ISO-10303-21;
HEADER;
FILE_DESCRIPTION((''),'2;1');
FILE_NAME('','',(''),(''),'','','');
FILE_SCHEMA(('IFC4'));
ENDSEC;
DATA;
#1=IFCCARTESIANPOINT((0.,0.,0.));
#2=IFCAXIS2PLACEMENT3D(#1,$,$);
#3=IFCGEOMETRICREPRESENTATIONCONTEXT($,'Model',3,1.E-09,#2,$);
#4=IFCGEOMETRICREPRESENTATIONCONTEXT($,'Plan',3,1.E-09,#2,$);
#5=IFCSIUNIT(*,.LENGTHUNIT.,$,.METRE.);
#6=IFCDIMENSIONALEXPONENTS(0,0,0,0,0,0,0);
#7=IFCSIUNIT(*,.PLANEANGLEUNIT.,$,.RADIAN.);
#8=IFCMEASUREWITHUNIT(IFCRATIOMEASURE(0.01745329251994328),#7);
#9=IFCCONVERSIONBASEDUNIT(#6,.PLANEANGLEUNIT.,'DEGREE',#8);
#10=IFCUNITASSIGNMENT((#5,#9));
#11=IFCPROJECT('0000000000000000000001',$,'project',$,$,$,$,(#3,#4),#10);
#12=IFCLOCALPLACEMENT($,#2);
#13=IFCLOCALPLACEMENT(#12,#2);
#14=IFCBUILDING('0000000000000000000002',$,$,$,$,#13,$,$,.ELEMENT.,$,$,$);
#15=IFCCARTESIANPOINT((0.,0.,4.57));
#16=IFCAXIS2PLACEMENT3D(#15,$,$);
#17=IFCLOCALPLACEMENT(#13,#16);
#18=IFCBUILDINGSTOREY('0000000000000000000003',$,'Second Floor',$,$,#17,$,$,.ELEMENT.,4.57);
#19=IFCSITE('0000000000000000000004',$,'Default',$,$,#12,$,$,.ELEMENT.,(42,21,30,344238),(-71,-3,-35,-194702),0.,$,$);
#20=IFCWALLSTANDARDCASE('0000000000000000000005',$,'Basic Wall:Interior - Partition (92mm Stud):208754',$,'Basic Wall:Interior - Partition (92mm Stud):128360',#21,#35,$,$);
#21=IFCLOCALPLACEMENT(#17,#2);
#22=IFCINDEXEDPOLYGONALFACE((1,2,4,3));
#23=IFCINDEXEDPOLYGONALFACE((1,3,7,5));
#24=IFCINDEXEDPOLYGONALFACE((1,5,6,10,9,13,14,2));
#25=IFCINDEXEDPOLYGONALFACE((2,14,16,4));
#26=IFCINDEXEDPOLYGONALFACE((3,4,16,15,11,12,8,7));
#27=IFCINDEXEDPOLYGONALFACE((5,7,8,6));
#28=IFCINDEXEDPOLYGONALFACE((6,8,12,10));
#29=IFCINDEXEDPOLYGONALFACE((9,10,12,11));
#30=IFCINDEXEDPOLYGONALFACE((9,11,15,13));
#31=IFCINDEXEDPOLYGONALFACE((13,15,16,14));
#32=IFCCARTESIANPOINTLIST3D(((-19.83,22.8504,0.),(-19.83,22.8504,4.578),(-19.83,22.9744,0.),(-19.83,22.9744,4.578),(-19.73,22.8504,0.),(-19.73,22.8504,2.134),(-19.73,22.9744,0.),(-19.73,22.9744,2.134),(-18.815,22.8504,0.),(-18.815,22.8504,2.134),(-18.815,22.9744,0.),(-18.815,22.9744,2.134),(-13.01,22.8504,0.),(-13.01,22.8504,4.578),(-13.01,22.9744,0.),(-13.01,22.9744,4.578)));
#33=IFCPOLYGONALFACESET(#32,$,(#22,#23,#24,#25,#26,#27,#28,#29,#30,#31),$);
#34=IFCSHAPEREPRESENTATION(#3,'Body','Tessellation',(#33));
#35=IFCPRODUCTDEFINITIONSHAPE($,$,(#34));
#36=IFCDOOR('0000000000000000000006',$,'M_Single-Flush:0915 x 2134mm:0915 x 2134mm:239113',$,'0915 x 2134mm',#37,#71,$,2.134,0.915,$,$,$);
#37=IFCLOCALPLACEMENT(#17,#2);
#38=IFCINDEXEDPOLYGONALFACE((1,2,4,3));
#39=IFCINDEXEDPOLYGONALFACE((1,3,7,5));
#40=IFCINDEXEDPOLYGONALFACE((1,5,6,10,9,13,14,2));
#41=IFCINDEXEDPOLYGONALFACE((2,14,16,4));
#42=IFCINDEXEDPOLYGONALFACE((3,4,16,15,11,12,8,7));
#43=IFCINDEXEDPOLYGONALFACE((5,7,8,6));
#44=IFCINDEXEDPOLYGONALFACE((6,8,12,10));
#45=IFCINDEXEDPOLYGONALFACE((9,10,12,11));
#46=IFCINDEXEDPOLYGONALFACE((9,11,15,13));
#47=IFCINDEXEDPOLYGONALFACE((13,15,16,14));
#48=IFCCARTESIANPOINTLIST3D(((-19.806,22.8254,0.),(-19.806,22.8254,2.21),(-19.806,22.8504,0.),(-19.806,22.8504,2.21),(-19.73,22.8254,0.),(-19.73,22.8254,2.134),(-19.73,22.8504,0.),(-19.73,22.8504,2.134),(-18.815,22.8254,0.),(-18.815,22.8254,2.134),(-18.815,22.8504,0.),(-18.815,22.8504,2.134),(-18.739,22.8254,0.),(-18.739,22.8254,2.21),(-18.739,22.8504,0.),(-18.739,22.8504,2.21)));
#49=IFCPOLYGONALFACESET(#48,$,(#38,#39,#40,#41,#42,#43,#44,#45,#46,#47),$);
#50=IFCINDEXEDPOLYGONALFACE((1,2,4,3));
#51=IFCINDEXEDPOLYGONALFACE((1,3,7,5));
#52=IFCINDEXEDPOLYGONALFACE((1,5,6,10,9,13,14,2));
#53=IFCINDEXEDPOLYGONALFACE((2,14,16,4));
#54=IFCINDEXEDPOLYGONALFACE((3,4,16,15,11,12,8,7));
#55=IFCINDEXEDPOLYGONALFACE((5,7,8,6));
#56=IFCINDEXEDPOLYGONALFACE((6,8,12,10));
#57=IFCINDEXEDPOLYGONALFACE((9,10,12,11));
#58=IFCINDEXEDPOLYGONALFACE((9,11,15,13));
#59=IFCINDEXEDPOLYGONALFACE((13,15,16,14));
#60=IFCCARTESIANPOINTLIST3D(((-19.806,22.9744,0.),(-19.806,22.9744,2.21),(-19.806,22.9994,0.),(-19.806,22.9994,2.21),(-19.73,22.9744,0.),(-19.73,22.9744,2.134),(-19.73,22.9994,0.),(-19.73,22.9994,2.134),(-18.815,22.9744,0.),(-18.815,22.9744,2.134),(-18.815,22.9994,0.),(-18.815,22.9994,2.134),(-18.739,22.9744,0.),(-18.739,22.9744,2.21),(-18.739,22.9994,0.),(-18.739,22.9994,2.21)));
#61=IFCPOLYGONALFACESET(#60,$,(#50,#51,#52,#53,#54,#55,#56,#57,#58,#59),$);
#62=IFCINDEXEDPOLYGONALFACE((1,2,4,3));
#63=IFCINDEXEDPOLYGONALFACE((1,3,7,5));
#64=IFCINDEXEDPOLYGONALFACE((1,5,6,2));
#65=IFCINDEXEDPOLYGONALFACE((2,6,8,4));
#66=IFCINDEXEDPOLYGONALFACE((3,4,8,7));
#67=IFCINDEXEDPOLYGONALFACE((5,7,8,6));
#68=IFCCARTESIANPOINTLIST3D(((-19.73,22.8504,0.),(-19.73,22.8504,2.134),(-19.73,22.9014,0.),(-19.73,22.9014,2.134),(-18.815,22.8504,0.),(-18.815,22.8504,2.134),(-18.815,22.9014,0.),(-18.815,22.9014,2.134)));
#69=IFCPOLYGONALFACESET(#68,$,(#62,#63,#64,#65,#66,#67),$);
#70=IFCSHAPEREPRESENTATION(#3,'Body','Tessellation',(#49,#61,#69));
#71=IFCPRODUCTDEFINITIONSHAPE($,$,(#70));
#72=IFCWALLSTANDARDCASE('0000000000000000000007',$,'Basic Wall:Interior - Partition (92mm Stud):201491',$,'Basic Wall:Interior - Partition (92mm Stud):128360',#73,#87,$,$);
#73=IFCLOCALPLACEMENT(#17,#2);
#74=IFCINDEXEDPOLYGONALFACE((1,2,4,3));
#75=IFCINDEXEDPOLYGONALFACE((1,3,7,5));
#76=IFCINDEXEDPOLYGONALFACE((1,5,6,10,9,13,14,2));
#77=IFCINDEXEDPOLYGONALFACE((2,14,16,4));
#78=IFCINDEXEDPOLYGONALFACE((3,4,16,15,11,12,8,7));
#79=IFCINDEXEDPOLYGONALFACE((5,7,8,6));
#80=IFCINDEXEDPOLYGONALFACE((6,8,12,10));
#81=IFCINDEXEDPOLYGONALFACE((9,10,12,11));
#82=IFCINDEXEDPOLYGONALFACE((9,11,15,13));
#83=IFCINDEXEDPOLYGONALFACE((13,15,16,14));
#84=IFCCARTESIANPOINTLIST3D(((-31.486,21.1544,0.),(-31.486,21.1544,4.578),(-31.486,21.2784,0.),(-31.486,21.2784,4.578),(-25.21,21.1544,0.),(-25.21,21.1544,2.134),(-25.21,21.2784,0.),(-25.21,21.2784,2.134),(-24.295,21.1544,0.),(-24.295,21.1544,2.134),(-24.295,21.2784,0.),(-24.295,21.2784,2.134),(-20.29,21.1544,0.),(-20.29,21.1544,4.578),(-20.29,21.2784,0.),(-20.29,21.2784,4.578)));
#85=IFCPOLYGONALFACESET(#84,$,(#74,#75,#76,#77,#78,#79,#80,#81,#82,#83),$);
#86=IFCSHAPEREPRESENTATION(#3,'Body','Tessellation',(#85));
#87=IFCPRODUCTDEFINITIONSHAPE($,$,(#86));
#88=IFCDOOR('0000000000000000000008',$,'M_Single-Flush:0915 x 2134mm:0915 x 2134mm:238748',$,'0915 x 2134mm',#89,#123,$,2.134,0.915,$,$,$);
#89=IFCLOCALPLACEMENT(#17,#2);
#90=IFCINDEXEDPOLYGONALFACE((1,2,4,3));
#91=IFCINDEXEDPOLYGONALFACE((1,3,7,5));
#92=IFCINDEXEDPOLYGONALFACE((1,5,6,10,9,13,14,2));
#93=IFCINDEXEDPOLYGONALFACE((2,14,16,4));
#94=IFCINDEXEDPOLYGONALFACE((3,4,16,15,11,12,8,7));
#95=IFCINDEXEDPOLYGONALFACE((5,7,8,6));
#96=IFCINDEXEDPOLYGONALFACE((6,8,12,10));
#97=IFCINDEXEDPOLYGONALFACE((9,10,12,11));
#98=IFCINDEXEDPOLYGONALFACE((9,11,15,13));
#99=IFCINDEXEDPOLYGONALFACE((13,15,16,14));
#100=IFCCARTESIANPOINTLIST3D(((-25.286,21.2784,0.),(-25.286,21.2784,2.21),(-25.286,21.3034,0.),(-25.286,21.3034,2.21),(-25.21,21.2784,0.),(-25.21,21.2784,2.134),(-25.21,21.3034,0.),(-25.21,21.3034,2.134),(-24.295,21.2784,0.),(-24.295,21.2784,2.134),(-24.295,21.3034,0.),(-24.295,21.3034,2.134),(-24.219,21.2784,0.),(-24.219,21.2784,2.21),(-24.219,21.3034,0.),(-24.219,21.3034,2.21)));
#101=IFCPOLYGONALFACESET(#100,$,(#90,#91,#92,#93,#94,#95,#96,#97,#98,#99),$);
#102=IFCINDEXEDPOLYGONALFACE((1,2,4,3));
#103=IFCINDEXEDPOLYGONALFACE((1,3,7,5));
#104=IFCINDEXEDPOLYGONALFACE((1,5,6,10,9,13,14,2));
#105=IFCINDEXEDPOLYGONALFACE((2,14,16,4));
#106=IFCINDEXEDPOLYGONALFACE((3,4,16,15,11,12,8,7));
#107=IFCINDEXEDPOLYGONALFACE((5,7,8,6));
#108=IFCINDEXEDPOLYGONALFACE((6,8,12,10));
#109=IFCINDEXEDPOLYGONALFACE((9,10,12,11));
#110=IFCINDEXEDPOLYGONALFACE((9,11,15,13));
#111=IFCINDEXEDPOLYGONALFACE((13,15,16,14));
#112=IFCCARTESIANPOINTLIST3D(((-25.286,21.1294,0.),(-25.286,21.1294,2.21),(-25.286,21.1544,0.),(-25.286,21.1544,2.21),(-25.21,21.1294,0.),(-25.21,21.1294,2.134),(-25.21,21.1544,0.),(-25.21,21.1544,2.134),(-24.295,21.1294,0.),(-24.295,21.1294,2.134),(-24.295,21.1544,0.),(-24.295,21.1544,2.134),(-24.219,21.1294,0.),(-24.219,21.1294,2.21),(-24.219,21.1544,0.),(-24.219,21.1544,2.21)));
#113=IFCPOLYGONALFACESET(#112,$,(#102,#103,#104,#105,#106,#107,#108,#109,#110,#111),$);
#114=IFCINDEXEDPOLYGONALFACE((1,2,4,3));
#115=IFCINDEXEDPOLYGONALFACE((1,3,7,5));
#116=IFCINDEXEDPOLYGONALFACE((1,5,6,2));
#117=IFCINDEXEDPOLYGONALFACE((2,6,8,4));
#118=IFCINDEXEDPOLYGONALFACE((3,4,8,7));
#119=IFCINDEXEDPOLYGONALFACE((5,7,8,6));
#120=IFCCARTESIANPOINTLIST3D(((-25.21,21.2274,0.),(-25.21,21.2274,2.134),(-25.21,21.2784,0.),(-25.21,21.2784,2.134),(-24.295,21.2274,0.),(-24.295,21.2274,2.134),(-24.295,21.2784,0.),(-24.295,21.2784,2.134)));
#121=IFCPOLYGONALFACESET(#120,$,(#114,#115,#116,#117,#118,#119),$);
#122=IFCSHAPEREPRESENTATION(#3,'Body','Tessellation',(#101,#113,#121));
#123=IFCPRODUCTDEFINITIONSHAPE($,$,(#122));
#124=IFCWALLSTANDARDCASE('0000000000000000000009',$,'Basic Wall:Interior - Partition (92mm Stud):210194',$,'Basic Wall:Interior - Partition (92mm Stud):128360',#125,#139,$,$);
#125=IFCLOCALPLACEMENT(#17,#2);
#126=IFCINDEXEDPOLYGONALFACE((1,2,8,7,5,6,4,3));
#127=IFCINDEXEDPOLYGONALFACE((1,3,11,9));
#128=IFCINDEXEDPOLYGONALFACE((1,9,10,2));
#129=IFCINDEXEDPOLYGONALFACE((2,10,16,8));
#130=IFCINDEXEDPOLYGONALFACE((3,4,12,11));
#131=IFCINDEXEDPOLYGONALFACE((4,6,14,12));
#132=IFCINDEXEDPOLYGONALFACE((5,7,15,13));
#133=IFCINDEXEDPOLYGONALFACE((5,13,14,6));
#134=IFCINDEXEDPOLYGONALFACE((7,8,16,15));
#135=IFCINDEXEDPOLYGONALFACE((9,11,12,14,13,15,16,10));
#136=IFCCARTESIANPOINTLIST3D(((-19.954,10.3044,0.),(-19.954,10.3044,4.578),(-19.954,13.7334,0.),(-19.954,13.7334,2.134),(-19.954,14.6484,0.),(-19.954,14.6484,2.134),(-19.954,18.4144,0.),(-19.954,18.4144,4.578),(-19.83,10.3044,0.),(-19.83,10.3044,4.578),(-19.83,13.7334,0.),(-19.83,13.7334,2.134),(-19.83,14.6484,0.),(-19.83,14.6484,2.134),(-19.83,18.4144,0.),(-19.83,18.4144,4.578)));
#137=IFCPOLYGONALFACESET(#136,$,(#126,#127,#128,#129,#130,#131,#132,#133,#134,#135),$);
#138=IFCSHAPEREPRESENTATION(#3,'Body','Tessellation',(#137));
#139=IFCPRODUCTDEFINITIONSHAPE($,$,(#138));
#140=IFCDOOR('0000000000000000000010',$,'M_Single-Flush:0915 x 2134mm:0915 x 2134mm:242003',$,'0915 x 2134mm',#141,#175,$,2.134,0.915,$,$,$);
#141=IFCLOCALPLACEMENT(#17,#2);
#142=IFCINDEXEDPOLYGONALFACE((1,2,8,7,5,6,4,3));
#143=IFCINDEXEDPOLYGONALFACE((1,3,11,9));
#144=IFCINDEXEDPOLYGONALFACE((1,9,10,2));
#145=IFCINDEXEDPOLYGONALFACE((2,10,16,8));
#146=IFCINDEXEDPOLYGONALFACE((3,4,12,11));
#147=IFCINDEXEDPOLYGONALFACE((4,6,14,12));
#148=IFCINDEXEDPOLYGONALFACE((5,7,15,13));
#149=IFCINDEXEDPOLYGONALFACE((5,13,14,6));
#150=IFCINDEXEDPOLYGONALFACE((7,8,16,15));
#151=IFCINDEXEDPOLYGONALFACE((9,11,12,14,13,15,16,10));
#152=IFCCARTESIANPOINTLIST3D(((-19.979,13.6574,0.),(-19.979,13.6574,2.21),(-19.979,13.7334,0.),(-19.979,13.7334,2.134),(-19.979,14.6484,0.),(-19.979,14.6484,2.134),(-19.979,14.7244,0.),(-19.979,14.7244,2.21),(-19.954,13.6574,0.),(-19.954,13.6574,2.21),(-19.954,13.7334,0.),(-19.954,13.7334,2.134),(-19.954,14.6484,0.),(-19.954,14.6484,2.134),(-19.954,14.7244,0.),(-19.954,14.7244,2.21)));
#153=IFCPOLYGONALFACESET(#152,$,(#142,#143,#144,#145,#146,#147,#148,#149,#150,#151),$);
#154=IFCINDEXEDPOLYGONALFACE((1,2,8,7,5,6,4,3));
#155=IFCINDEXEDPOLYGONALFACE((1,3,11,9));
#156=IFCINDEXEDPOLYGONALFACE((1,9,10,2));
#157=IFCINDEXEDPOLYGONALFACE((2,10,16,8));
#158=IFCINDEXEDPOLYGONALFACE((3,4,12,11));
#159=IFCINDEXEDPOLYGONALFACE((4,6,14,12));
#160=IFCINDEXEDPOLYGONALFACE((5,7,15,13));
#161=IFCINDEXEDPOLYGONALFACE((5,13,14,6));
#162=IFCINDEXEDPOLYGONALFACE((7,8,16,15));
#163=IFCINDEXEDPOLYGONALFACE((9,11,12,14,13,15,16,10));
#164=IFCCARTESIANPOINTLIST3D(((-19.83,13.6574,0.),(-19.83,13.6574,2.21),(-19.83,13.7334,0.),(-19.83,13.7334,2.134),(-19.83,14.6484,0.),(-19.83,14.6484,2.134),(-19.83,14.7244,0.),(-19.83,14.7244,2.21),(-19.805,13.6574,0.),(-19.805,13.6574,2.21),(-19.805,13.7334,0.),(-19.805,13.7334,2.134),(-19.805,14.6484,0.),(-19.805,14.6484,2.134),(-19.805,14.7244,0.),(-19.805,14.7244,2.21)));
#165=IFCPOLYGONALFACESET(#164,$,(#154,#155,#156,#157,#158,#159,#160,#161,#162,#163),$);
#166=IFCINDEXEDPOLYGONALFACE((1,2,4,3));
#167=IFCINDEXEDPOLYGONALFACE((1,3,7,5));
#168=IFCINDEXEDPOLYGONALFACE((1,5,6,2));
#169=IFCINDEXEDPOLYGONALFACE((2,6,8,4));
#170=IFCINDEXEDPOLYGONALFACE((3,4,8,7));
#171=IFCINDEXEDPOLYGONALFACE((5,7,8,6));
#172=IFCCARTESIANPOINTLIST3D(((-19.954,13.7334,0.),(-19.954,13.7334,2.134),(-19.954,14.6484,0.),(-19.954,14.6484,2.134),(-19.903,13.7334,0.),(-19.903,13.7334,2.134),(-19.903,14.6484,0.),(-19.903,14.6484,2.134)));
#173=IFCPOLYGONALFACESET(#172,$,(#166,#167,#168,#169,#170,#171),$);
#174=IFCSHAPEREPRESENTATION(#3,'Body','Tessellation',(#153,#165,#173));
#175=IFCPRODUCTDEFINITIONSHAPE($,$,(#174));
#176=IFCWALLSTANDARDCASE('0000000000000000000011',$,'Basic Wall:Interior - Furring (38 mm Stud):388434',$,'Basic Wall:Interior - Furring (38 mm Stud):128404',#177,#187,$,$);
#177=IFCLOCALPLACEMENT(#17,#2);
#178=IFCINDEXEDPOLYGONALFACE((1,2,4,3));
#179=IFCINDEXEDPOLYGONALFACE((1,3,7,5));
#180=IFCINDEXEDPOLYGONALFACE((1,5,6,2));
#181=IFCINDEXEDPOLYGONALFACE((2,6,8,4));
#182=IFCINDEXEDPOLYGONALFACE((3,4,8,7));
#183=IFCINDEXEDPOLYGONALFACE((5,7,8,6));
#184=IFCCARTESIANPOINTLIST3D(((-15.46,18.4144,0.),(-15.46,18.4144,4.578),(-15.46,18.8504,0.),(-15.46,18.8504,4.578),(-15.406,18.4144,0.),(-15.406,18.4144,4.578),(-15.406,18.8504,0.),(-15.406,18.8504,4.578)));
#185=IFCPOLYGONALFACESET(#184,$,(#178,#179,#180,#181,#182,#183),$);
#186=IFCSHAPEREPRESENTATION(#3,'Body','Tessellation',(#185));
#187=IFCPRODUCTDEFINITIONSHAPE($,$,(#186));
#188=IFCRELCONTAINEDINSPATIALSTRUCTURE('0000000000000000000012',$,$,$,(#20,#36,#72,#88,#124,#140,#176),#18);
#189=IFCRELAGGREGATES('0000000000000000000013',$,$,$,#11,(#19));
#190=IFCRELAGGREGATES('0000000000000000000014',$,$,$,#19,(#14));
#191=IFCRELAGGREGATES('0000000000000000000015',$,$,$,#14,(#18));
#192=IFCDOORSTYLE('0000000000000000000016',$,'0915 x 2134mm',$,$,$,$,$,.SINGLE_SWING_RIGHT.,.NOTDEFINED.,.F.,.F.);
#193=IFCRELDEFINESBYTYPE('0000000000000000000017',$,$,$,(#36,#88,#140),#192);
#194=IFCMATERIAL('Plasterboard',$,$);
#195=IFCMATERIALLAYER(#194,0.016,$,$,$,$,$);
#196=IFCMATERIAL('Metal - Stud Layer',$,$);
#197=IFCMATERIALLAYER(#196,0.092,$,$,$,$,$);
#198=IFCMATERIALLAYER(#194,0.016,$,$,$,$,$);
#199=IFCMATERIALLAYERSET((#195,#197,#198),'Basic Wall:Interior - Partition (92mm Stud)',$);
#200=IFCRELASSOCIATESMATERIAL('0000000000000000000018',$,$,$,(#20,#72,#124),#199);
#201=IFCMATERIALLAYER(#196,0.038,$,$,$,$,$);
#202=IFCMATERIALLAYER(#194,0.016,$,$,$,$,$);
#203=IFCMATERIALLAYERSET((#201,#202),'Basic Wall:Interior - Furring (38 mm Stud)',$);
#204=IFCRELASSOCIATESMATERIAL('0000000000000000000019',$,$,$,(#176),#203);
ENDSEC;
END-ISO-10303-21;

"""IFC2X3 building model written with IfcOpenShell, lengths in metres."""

from ifc_helpers import new_model, entity, si_unit, converted_unit, frame, frame_2d, origin, origin_2d_with_axis, place, context, project, spatial, polyline, rectangle, outline, extrude, source, transform, mapped, material, layer, layer_set, layer_usage, type_object, type_shapes, element, fill, save


model = new_model("IFC2X3")

# Units and contexts
model_context = context("Model", 3, precision=1e-09, world=origin())
plan_context = context("Plan", 3, precision=1e-09, world=origin())
ifc_project = project(units=[si_unit("LENGTHUNIT", "METRE"), converted_unit("PLANEANGLEUNIT", "DEGREE", entity("IfcRatioMeasure", 0.01745329251994328), si_unit("PLANEANGLEUNIT", "RADIAN"), dimensions=[0, 0, 0, 0, 0, 0, 0])], contexts=[model_context, plan_context])

# Site, building, storey
site_placement = place(None, origin())
site = spatial("IfcSite", under=ifc_project, at=site_placement, Name="Default", CompositionType="ELEMENT", RefLatitude=(42, 21, 30, 344238), RefLongitude=(-71, -3, -35, -194702), RefElevation=0.0)
building_placement = place(site_placement, origin())
building = spatial("IfcBuilding", under=site, at=building_placement, CompositionType="ELEMENT")
storey_placement = place(building_placement, frame((0.0, 0.0, 4.57)))
storey = spatial("IfcBuildingStorey", under=building, at=storey_placement, Name="Second Floor", CompositionType="ELEMENT", Elevation=4.57)

# Shared definitions
ifc_material_1 = material(Name="Plasterboard")
ifc_layer_1 = layer(ifc_material_1, 0.016)
ifc_material_2 = material(Name="Metal - Stud Layer")
ifc_layer_2 = layer(ifc_material_2, 0.092)
ifc_layer_3 = layer(ifc_material_1, 0.016)
ifc_layer_set_1 = layer_set([ifc_layer_1, ifc_layer_2, ifc_layer_3], Name="Basic Wall:Interior - Partition (92mm Stud)")
ifc_layer_usage_1 = layer_usage(ifc_layer_set_1, "AXIS2", "NEGATIVE", 0.062)
door_style_1 = type_object("IfcDoorStyle", Name="0915 x 2134mm", ConstructionType="NOTDEFINED", OperationType="SINGLE_SWING_RIGHT", ParameterTakesPrecedence=False, Sizeable=False)
shared_shape_1 = source(origin(), model_context, "Body", "SweptSolid", [
    extrude(outline(polyline([(-0.5335, -1.124), (0.5335, -1.124), (0.5335, 1.086), (0.4575, 1.086), (0.4575, -1.048), (-0.4575, -1.048), (-0.4575, 1.086), (-0.5335, 1.086), (-0.5335, -1.124)])), frame((0.4575, 0.124, 1.086), z_axis=(0.0, 1.0, 0.0), x_axis=(1.0, 0.0, 0.0)), (0.0, 0.0, 1.0), 0.025),
    extrude(outline(polyline([(-1.124, -0.5335), (1.086, -0.5335), (1.086, -0.4575), (-1.048, -0.4575), (-1.048, 0.4575), (1.086, 0.4575), (1.086, 0.5335), (-1.124, 0.5335), (-1.124, -0.5335)])), frame((0.4575, -0.025, 1.086), z_axis=(0.0, 1.0, 0.0), x_axis=(0.0, 0.0, -1.0)), (0.0, 0.0, 1.0), 0.025),
    extrude(rectangle(XDim=0.051, YDim=0.915, at=origin_2d_with_axis()), frame((0.4575, 0.0985, 0.0), z_axis=(0.0, 0.0, 1.0), x_axis=(0.0, 1.0, 0.0)), (0.0, 0.0, 1.0), 2.134),
])
type_shapes(door_style_1, [shared_shape_1])

# Walls, openings, doors
wall_1_placement = place(storey_placement, frame((-13.01, 22.9124, 0.0), z_axis=(0.0, 0.0, 1.0), x_axis=(-1.0, 0.0, 0.0)))
wall_1 = element("IfcWallStandardCase", 1, at=wall_1_placement, inside=storey, material=ifc_layer_usage_1, Name="Basic Wall:Interior - Partition (92mm Stud):208754", ObjectType="Basic Wall:Interior - Partition (92mm Stud):128360", context=model_context, shape_type="SweptSolid", body=[
    extrude(rectangle(XDim=6.82, YDim=0.124, at=frame_2d((3.41, 0.0), x_axis=(-1.0, 0.0))), origin(), (0.0, 0.0, 1.0), 4.578),
])
opening_1_placement = place(wall_1_placement, frame((5.805, -0.062, 0.0)))
opening_1 = element("IfcOpeningElement", 2, at=opening_1_placement, cuts=wall_1, ObjectType="Opening", context=model_context, shape_type="SweptSolid", body=[
    extrude(rectangle(XDim=0.915, YDim=2.134, at=frame_2d((1.067, 0.4575), x_axis=(0.0, 1.0))), frame((0.0, 0.0, 0.0), z_axis=(0.0, 1.0, 0.0), x_axis=(0.0, 0.0, 1.0)), (0.0, 0.0, 1.0), 0.124),
])
door_1_placement = place(opening_1_placement, origin())
door_1 = element("IfcDoor", 3, at=door_1_placement, inside=storey, type_object=door_style_1, Name="M_Single-Flush:0915 x 2134mm:0915 x 2134mm:239113", ObjectType="0915 x 2134mm", OverallHeight=2.134, OverallWidth=0.915, context=model_context, shape_type="MappedRepresentation", body=[
    mapped(shared_shape_1, transform((0.0, 0.0, 0.0), scale=1.0)),
])
fill(opening_1, door_1)
wall_2_placement = place(storey_placement, frame((-20.29, 21.2164, 0.0), z_axis=(0.0, 0.0, 1.0), x_axis=(-1.0, 0.0, 0.0)))
wall_2 = element("IfcWallStandardCase", 4, at=wall_2_placement, inside=storey, material=ifc_layer_usage_1, Name="Basic Wall:Interior - Partition (92mm Stud):201491", ObjectType="Basic Wall:Interior - Partition (92mm Stud):128360", context=model_context, shape_type="SweptSolid", body=[
    extrude(rectangle(XDim=11.196, YDim=0.124, at=frame_2d((5.598, 0.0), x_axis=(-1.0, 0.0))), origin(), (0.0, 0.0, 1.0), 4.578),
])
opening_2_placement = place(wall_2_placement, frame((4.92, 0.062, 0.0)))
opening_2 = element("IfcOpeningElement", 5, at=opening_2_placement, cuts=wall_2, ObjectType="Opening", context=model_context, shape_type="SweptSolid", body=[
    extrude(rectangle(XDim=0.915, YDim=2.134, at=frame_2d((1.067, 0.4575), x_axis=(0.0, 1.0))), frame((0.0, 0.0, 0.0), z_axis=(0.0, -1.0, 0.0), x_axis=(0.0, 0.0, 1.0)), (0.0, 0.0, 1.0), 0.124),
])
door_2_placement = place(opening_2_placement, frame((0.0, 0.0, 0.0), z_axis=(0.0, 0.0, 1.0), x_axis=(-1.0, 0.0, 0.0)))
door_2 = element("IfcDoor", 6, at=door_2_placement, inside=storey, type_object=door_style_1, Name="M_Single-Flush:0915 x 2134mm:0915 x 2134mm:238748", ObjectType="0915 x 2134mm", OverallHeight=2.134, OverallWidth=0.915, context=model_context, shape_type="MappedRepresentation", body=[
    mapped(shared_shape_1, transform((0.0, 0.0, 0.0), scale=1.0)),
])
fill(opening_2, door_2)
wall_3_placement = place(storey_placement, frame((-19.892, 18.4144, 0.0), z_axis=(0.0, 0.0, 1.0), x_axis=(0.0, -1.0, 0.0)))
wall_3 = element("IfcWallStandardCase", 7, at=wall_3_placement, inside=storey, material=ifc_layer_usage_1, Name="Basic Wall:Interior - Partition (92mm Stud):210194", ObjectType="Basic Wall:Interior - Partition (92mm Stud):128360", context=model_context, shape_type="SweptSolid", body=[
    extrude(rectangle(XDim=8.11, YDim=0.124, at=frame_2d((4.055, 0.0), x_axis=(-1.0, 0.0))), origin(), (0.0, 0.0, 1.0), 4.578),
])
opening_3_placement = place(wall_3_placement, frame((4.681, 0.062, 0.0)))
opening_3 = element("IfcOpeningElement", 8, at=opening_3_placement, cuts=wall_3, ObjectType="Opening", context=model_context, shape_type="SweptSolid", body=[
    extrude(rectangle(XDim=0.915, YDim=2.134, at=frame_2d((1.067, 0.4575), x_axis=(0.0, 1.0))), frame((0.0, 0.0, 0.0), z_axis=(0.0, -1.0, 0.0), x_axis=(0.0, 0.0, 1.0)), (0.0, 0.0, 1.0), 0.124),
])
door_3_placement = place(opening_3_placement, frame((0.0, 0.0, 0.0), z_axis=(0.0, 0.0, 1.0), x_axis=(-1.0, 0.0, 0.0)))
door_3 = element("IfcDoor", 9, at=door_3_placement, inside=storey, type_object=door_style_1, Name="M_Single-Flush:0915 x 2134mm:0915 x 2134mm:242003", ObjectType="0915 x 2134mm", OverallHeight=2.134, OverallWidth=0.915, context=model_context, shape_type="MappedRepresentation", body=[
    mapped(shared_shape_1, transform((0.0, 0.0, 0.0), scale=1.0)),
])
fill(opening_3, door_3)

# Wall
ifc_layer_4 = layer(ifc_material_2, 0.038)
ifc_layer_5 = layer(ifc_material_1, 0.016)
ifc_layer_set_2 = layer_set([ifc_layer_4, ifc_layer_5], Name="Basic Wall:Interior - Furring (38 mm Stud)")
ifc_layer_usage_2 = layer_usage(ifc_layer_set_2, "AXIS2", "POSITIVE", -0.027)
wall_4_placement = place(storey_placement, frame((-15.433, 18.4144, 0.0), z_axis=(0.0, 0.0, 1.0), x_axis=(0.0, 1.0, 0.0)))
element("IfcWallStandardCase", 10, at=wall_4_placement, inside=storey, material=ifc_layer_usage_2, Name="Basic Wall:Interior - Furring (38 mm Stud):388434", ObjectType="Basic Wall:Interior - Furring (38 mm Stud):128404", context=model_context, shape_type="SweptSolid", body=[
    extrude(rectangle(XDim=0.436, YDim=0.054, at=frame_2d((0.218, 0.0), x_axis=(-1.0, 0.0))), origin(), (0.0, 0.0, 1.0), 4.578),
])

save(model, "model.ifc")
